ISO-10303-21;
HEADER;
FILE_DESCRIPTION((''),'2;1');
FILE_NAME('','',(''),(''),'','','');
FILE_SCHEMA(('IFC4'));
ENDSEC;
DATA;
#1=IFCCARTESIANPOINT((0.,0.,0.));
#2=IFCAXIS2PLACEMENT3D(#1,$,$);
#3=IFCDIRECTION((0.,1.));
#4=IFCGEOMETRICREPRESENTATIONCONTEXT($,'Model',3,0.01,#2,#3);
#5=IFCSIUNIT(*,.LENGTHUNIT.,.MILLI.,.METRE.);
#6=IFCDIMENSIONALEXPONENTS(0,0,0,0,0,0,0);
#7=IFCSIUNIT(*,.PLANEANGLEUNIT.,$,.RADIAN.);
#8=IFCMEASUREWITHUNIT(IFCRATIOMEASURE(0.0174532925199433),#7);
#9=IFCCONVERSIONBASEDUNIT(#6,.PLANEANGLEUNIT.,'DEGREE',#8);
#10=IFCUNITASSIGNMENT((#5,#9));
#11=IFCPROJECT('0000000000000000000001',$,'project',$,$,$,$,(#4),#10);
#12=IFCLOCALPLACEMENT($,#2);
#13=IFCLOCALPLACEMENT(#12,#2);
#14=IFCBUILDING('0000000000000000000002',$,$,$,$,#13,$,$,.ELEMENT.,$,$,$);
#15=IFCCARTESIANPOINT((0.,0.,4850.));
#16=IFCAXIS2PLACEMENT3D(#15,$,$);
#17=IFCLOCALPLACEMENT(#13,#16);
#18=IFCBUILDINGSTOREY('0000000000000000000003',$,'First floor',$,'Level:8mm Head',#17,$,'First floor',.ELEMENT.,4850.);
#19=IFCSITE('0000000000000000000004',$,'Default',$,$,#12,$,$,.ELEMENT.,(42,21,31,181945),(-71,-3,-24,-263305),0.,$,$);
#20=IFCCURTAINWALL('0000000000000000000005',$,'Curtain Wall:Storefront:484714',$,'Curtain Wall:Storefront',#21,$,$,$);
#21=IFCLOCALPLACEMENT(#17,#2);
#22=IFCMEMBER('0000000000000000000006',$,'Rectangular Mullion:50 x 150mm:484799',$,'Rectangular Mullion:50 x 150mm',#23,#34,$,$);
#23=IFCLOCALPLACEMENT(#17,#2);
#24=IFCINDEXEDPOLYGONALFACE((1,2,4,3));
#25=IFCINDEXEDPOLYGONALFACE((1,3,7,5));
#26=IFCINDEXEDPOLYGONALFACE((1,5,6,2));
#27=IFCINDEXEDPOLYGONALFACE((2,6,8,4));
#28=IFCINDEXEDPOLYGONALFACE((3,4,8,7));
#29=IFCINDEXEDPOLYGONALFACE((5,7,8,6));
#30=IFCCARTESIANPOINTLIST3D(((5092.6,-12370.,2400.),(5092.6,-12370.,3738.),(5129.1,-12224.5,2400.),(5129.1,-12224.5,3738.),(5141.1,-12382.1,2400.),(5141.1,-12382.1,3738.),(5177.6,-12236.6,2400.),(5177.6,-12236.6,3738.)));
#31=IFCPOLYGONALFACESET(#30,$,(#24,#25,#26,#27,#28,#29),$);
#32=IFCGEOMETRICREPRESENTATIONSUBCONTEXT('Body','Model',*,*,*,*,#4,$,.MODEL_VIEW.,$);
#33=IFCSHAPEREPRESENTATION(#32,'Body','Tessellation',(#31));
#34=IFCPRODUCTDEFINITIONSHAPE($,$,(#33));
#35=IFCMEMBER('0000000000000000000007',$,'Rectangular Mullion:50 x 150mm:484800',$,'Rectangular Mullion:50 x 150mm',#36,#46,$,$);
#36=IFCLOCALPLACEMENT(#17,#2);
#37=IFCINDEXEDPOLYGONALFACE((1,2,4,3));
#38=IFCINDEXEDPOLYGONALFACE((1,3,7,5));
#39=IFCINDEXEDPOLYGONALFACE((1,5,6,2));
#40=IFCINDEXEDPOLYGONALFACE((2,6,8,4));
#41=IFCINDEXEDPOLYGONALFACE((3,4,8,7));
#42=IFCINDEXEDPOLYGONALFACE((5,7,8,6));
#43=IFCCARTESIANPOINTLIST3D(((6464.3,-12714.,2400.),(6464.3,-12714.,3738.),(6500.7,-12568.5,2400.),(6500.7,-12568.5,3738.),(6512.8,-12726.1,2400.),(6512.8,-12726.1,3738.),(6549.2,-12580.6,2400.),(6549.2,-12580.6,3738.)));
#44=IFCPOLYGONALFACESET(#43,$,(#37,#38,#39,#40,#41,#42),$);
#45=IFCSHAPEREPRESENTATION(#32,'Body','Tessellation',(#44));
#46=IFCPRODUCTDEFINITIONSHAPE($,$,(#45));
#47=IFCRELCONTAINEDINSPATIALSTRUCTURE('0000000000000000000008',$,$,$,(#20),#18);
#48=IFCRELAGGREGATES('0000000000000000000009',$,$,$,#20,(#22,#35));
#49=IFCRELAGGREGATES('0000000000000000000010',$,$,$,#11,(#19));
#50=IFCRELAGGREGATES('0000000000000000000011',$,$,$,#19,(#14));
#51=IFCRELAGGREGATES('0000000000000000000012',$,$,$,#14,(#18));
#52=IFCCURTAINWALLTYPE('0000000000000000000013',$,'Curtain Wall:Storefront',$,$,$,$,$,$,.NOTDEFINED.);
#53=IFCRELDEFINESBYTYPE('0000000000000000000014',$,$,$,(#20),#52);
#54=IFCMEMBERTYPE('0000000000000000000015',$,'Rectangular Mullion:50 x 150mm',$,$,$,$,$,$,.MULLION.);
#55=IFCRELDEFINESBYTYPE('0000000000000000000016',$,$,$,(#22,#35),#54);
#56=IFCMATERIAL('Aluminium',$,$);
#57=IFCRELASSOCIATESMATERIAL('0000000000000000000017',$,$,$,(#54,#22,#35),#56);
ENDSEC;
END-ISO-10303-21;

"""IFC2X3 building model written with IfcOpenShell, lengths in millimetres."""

from ifc_helpers import new_model, entity, si_unit, converted_unit, direction, frame, origin, origin_2d_with_axis, place, context, subcontext, project, spatial, rectangle, extrude, source, transform, mapped, material, type_object, type_shapes, element, aggregate, save


model = new_model("IFC2X3")

# Units and contexts
model_context = context("Model", 3, precision=0.01, world=origin(), true_north=direction((0.0, 1.0)))
body_context = subcontext(model_context, "Body", "Model", "MODEL_VIEW")
ifc_project = project(units=[si_unit("LENGTHUNIT", "METRE", prefix="MILLI"), converted_unit("PLANEANGLEUNIT", "DEGREE", entity("IfcRatioMeasure", 0.0174532925199433), si_unit("PLANEANGLEUNIT", "RADIAN"), dimensions=[0, 0, 0, 0, 0, 0, 0])], contexts=[model_context])

# Site, building, storey
site_placement = place(None, origin())
site = spatial("IfcSite", under=ifc_project, at=site_placement, Name="Default", CompositionType="ELEMENT", RefLatitude=(42, 21, 31, 181945), RefLongitude=(-71, -3, -24, -263305), RefElevation=0.0)
building_placement = place(site_placement, origin())
building = spatial("IfcBuilding", under=site, at=building_placement, CompositionType="ELEMENT")
storey_placement = place(building_placement, frame((0.0, 0.0, 4850.0)))
storey = spatial("IfcBuildingStorey", under=building, at=storey_placement, Name="First floor", ObjectType="Level:8mm Head", LongName="First floor", CompositionType="ELEMENT", Elevation=4850.0)

# Curtain wall, members
curtain_wall_type = type_object("IfcCurtainWallType", Name="Curtain Wall:Storefront", PredefinedType="NOTDEFINED")
curtain_wall_placement = place(storey_placement, frame((0.0, 0.0, -4850.0)))
curtain_wall = element("IfcCurtainWall", 1, at=curtain_wall_placement, inside=storey, type_object=curtain_wall_type, Name="Curtain Wall:Storefront:484714", ObjectType="Curtain Wall:Storefront")
ifc_material_1 = material(Name="Aluminium")
member_type_1 = type_object("IfcMemberType", Name="Rectangular Mullion:50 x 150mm", PredefinedType="MULLION", material=ifc_material_1)
shared_shape_1 = source(origin(), body_context, "Body", "SweptSolid", [
    extrude(rectangle(XDim=150.0, YDim=50.0, at=origin_2d_with_axis()), frame((0.0, 0.0, -1338.0), z_axis=(0.0, 0.0, 1.0), x_axis=(0.0, -1.0, 0.0)), (0.0, 0.0, 1.0), 1338.0),
])
type_shapes(member_type_1, [shared_shape_1])
member_1_placement = place(storey_placement, frame((5135.1, -12303.3, 2400.0), z_axis=(0.0, 0.0, -1.0), x_axis=(0.96996, -0.243265, 0.0)))
member_1 = element("IfcMember", 2, at=member_1_placement, type_object=member_type_1, material=ifc_material_1, Name="Rectangular Mullion:50 x 150mm:484799", ObjectType="Rectangular Mullion:50 x 150mm", context=body_context, shape_type="MappedRepresentation", body=[
    mapped(shared_shape_1, transform((0.0, 0.0, 0.0), scale=1.0)),
])
member_2_placement = place(storey_placement, frame((6506.8, -12647.3, 2400.0), z_axis=(0.0, 0.0, -1.0), x_axis=(0.96996, -0.243265, 0.0)))
member_2 = element("IfcMember", 3, at=member_2_placement, type_object=member_type_1, material=ifc_material_1, Name="Rectangular Mullion:50 x 150mm:484800", ObjectType="Rectangular Mullion:50 x 150mm", context=body_context, shape_type="MappedRepresentation", body=[
    mapped(shared_shape_1, transform((0.0, 0.0, 0.0), scale=1.0)),
])
aggregate(curtain_wall, [member_1, member_2])

save(model, "model.ifc")
